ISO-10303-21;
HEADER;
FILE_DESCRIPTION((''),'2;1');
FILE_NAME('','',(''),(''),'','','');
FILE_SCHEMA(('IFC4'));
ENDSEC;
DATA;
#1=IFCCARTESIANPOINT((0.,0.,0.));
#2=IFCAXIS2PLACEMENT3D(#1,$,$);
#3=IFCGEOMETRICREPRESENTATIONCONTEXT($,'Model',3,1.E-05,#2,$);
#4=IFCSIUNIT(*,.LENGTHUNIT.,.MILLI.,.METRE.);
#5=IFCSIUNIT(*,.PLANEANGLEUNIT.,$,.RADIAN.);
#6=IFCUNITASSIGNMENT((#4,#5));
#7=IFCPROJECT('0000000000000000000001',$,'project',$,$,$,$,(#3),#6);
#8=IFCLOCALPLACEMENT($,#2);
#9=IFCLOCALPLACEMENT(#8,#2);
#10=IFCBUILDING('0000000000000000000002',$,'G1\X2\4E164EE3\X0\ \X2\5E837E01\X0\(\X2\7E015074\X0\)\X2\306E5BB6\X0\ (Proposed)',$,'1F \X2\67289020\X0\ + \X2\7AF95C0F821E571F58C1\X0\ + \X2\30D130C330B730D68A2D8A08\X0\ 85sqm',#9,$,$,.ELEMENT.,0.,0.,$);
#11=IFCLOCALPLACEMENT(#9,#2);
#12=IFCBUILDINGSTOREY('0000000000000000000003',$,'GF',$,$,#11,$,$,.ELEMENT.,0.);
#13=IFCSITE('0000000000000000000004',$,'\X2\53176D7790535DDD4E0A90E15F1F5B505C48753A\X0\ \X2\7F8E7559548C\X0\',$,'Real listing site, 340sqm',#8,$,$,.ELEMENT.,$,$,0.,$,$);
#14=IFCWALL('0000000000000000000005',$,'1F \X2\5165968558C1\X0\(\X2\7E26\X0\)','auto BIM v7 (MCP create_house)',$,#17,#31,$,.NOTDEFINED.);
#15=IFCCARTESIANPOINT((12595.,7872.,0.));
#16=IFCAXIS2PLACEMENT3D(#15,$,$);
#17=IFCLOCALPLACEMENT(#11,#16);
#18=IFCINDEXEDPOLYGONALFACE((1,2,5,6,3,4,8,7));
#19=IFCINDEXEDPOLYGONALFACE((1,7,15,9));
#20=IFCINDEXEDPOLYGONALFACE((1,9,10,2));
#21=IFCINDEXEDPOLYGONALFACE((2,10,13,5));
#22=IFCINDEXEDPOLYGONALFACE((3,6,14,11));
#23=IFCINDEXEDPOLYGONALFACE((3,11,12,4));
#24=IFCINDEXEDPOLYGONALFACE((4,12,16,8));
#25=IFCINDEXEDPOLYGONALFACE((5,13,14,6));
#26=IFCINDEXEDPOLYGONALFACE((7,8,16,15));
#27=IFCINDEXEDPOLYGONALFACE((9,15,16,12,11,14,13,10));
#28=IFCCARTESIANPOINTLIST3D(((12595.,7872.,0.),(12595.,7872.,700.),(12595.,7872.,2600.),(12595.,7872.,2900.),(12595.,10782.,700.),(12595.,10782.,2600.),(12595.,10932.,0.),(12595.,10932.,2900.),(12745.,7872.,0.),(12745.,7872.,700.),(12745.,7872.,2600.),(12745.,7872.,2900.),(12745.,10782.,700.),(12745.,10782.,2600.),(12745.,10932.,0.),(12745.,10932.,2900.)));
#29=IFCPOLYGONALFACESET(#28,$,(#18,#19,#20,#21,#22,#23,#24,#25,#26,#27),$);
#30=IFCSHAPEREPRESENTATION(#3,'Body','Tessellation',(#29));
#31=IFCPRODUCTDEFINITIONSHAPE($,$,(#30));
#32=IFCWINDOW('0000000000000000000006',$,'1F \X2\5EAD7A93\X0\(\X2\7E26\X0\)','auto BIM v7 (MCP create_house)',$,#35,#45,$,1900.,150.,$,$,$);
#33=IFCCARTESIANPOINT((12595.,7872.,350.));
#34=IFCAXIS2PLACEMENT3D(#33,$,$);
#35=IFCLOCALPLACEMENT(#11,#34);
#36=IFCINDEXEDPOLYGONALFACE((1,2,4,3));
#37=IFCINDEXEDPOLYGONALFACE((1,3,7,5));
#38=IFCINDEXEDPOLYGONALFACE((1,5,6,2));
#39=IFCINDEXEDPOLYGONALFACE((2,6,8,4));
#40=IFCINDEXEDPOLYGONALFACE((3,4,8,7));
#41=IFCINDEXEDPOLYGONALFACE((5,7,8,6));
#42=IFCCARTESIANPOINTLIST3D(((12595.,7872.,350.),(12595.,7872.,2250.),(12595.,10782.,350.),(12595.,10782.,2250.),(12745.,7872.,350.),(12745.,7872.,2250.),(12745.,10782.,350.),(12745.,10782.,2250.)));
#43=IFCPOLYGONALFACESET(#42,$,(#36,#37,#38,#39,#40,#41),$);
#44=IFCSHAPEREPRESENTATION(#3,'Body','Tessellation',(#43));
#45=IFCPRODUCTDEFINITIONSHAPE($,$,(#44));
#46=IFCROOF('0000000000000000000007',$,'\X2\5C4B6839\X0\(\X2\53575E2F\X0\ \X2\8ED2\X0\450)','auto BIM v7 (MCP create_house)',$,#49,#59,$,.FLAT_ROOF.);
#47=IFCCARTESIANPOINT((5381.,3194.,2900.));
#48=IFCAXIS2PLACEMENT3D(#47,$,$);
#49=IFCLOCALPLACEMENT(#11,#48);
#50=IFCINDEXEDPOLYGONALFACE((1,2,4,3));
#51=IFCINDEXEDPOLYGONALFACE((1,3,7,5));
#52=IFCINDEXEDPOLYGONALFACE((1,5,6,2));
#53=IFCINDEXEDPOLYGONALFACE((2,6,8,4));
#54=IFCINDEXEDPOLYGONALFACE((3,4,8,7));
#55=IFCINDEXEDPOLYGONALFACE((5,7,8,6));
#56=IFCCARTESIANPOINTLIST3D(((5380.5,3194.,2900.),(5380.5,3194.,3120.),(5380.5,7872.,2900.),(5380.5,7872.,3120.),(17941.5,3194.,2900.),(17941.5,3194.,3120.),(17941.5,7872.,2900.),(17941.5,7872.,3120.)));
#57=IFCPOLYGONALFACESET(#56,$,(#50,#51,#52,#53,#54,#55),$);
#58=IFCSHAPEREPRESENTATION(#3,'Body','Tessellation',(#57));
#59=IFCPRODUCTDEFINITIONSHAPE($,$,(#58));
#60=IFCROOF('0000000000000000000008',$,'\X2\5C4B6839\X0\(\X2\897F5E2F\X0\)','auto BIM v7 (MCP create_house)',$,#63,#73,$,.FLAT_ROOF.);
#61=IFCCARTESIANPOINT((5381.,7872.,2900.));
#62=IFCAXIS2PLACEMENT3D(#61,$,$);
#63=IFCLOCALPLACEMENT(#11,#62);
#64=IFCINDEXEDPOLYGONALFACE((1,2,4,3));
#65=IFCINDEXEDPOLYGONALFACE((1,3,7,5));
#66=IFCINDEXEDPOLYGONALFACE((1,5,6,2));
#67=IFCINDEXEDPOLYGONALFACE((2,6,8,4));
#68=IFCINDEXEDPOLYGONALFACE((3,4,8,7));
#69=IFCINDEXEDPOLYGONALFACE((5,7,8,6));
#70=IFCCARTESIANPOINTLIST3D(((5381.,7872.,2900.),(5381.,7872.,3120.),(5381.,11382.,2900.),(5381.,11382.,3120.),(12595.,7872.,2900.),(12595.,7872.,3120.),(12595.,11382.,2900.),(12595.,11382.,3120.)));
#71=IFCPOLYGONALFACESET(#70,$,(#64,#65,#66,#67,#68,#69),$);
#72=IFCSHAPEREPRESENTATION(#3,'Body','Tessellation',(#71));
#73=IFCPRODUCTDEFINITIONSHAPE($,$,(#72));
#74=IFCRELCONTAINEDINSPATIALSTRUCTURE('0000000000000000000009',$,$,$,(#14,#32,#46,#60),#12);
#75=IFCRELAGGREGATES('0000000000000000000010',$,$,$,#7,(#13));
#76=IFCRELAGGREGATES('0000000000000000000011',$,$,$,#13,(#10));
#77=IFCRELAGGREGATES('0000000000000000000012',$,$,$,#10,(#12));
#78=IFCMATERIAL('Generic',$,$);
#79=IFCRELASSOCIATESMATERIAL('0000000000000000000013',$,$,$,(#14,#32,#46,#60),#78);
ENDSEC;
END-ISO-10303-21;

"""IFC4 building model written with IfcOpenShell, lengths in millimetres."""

from ifc_helpers import new_model, si_unit, frame, frame_2d, origin, place, context, project, spatial, rectangle, extrude, material, element, fill, save


model = new_model("IFC4")

# Units and contexts
model_context = context("Model", 3, precision=1e-05, world=origin())
ifc_project = project(units=[si_unit("LENGTHUNIT", "METRE", prefix="MILLI"), si_unit("PLANEANGLEUNIT", "RADIAN")], contexts=[model_context])

# Site, building, storey
site_placement = place(None, origin())
site = spatial("IfcSite", under=ifc_project, at=site_placement, Name="北海道川上郡弟子屈町 美留和", ObjectType="Real listing site, 340sqm", CompositionType="ELEMENT", RefElevation=0.0)
building_placement = place(site_placement, origin())
building = spatial("IfcBuilding", under=site, at=building_placement, Name="G1世代 広縁(縁側)の家 (Proposed)", ObjectType="1F 木造 + 竹小舞土壁 + パッシブ設計 85sqm", CompositionType="ELEMENT", ElevationOfRefHeight=0.0, ElevationOfTerrain=0.0)
storey_placement = place(building_placement, origin())
storey = spatial("IfcBuildingStorey", under=building, at=storey_placement, Name="GF", CompositionType="ELEMENT", Elevation=0.0)

# Shared definitions
ifc_material = material(Name="Generic")

# Wall, opening, window
wall_1_placement = place(storey_placement, frame((12595.0, 7872.0, 0.0)))
wall_1 = element("IfcWall", 1, at=wall_1_placement, inside=storey, material=ifc_material, Name="1F 入隅壁(縦)", Description="auto BIM v7 (MCP create_house)", PredefinedType="NOTDEFINED", context=model_context, shape_type="SweptSolid", body=[
    extrude(rectangle(XDim=150.0, YDim=3060.0, at=frame_2d((75.0, 1530.0))), frame((12595.0, 7872.0, 0.0)), (0.0, 0.0, 1.0), 2900.0),
])
opening_1_placement = place(storey_placement, frame((12595.0, 7872.0, 350.0)))
opening_1 = element("IfcOpeningElement", 2, at=opening_1_placement, cuts=wall_1, PredefinedType="NOTDEFINED", context=model_context, shape_type="SweptSolid", body=[
    extrude(rectangle(XDim=150.0, YDim=2910.0, at=frame_2d((75.0, 1455.0))), frame((12595.0, 7872.0, 350.0)), (0.0, 0.0, 1.0), 1900.0),
])
window_1_placement = place(storey_placement, frame((12595.0, 7872.0, 350.0)))
window_1 = element("IfcWindow", 3, at=window_1_placement, inside=storey, material=ifc_material, Name="1F 庭窓(縦)", Description="auto BIM v7 (MCP create_house)", OverallHeight=1900.0, OverallWidth=150.0, context=model_context, shape_type="SweptSolid", body=[
    extrude(rectangle(XDim=150.0, YDim=2910.0, at=frame_2d((75.0, 1455.0))), frame((12595.0, 7872.0, 350.0)), (0.0, 0.0, 1.0), 1900.0),
])
fill(opening_1, window_1)

# Roofs
roof_1_placement = place(storey_placement, frame((5381.0, 3194.0, 2900.0)))
element("IfcRoof", 4, at=roof_1_placement, inside=storey, material=ifc_material, Name="屋根(南帯 軒450)", Description="auto BIM v7 (MCP create_house)", PredefinedType="FLAT_ROOF", context=model_context, shape_type="SweptSolid", body=[
    extrude(rectangle(XDim=12561.0, YDim=4678.0, at=frame_2d((6280.0, 2339.0))), frame((5381.0, 3194.0, 2900.0)), (0.0, 0.0, 1.0), 220.0),
])
roof_2_placement = place(storey_placement, frame((5381.0, 7872.0, 2900.0)))
element("IfcRoof", 5, at=roof_2_placement, inside=storey, material=ifc_material, Name="屋根(西帯)", Description="auto BIM v7 (MCP create_house)", PredefinedType="FLAT_ROOF", context=model_context, shape_type="SweptSolid", body=[
    extrude(rectangle(XDim=7214.0, YDim=3510.0, at=frame_2d((3607.0, 1755.0))), frame((5381.0, 7872.0, 2900.0)), (0.0, 0.0, 1.0), 220.0),
])

save(model, "model.ifc")
